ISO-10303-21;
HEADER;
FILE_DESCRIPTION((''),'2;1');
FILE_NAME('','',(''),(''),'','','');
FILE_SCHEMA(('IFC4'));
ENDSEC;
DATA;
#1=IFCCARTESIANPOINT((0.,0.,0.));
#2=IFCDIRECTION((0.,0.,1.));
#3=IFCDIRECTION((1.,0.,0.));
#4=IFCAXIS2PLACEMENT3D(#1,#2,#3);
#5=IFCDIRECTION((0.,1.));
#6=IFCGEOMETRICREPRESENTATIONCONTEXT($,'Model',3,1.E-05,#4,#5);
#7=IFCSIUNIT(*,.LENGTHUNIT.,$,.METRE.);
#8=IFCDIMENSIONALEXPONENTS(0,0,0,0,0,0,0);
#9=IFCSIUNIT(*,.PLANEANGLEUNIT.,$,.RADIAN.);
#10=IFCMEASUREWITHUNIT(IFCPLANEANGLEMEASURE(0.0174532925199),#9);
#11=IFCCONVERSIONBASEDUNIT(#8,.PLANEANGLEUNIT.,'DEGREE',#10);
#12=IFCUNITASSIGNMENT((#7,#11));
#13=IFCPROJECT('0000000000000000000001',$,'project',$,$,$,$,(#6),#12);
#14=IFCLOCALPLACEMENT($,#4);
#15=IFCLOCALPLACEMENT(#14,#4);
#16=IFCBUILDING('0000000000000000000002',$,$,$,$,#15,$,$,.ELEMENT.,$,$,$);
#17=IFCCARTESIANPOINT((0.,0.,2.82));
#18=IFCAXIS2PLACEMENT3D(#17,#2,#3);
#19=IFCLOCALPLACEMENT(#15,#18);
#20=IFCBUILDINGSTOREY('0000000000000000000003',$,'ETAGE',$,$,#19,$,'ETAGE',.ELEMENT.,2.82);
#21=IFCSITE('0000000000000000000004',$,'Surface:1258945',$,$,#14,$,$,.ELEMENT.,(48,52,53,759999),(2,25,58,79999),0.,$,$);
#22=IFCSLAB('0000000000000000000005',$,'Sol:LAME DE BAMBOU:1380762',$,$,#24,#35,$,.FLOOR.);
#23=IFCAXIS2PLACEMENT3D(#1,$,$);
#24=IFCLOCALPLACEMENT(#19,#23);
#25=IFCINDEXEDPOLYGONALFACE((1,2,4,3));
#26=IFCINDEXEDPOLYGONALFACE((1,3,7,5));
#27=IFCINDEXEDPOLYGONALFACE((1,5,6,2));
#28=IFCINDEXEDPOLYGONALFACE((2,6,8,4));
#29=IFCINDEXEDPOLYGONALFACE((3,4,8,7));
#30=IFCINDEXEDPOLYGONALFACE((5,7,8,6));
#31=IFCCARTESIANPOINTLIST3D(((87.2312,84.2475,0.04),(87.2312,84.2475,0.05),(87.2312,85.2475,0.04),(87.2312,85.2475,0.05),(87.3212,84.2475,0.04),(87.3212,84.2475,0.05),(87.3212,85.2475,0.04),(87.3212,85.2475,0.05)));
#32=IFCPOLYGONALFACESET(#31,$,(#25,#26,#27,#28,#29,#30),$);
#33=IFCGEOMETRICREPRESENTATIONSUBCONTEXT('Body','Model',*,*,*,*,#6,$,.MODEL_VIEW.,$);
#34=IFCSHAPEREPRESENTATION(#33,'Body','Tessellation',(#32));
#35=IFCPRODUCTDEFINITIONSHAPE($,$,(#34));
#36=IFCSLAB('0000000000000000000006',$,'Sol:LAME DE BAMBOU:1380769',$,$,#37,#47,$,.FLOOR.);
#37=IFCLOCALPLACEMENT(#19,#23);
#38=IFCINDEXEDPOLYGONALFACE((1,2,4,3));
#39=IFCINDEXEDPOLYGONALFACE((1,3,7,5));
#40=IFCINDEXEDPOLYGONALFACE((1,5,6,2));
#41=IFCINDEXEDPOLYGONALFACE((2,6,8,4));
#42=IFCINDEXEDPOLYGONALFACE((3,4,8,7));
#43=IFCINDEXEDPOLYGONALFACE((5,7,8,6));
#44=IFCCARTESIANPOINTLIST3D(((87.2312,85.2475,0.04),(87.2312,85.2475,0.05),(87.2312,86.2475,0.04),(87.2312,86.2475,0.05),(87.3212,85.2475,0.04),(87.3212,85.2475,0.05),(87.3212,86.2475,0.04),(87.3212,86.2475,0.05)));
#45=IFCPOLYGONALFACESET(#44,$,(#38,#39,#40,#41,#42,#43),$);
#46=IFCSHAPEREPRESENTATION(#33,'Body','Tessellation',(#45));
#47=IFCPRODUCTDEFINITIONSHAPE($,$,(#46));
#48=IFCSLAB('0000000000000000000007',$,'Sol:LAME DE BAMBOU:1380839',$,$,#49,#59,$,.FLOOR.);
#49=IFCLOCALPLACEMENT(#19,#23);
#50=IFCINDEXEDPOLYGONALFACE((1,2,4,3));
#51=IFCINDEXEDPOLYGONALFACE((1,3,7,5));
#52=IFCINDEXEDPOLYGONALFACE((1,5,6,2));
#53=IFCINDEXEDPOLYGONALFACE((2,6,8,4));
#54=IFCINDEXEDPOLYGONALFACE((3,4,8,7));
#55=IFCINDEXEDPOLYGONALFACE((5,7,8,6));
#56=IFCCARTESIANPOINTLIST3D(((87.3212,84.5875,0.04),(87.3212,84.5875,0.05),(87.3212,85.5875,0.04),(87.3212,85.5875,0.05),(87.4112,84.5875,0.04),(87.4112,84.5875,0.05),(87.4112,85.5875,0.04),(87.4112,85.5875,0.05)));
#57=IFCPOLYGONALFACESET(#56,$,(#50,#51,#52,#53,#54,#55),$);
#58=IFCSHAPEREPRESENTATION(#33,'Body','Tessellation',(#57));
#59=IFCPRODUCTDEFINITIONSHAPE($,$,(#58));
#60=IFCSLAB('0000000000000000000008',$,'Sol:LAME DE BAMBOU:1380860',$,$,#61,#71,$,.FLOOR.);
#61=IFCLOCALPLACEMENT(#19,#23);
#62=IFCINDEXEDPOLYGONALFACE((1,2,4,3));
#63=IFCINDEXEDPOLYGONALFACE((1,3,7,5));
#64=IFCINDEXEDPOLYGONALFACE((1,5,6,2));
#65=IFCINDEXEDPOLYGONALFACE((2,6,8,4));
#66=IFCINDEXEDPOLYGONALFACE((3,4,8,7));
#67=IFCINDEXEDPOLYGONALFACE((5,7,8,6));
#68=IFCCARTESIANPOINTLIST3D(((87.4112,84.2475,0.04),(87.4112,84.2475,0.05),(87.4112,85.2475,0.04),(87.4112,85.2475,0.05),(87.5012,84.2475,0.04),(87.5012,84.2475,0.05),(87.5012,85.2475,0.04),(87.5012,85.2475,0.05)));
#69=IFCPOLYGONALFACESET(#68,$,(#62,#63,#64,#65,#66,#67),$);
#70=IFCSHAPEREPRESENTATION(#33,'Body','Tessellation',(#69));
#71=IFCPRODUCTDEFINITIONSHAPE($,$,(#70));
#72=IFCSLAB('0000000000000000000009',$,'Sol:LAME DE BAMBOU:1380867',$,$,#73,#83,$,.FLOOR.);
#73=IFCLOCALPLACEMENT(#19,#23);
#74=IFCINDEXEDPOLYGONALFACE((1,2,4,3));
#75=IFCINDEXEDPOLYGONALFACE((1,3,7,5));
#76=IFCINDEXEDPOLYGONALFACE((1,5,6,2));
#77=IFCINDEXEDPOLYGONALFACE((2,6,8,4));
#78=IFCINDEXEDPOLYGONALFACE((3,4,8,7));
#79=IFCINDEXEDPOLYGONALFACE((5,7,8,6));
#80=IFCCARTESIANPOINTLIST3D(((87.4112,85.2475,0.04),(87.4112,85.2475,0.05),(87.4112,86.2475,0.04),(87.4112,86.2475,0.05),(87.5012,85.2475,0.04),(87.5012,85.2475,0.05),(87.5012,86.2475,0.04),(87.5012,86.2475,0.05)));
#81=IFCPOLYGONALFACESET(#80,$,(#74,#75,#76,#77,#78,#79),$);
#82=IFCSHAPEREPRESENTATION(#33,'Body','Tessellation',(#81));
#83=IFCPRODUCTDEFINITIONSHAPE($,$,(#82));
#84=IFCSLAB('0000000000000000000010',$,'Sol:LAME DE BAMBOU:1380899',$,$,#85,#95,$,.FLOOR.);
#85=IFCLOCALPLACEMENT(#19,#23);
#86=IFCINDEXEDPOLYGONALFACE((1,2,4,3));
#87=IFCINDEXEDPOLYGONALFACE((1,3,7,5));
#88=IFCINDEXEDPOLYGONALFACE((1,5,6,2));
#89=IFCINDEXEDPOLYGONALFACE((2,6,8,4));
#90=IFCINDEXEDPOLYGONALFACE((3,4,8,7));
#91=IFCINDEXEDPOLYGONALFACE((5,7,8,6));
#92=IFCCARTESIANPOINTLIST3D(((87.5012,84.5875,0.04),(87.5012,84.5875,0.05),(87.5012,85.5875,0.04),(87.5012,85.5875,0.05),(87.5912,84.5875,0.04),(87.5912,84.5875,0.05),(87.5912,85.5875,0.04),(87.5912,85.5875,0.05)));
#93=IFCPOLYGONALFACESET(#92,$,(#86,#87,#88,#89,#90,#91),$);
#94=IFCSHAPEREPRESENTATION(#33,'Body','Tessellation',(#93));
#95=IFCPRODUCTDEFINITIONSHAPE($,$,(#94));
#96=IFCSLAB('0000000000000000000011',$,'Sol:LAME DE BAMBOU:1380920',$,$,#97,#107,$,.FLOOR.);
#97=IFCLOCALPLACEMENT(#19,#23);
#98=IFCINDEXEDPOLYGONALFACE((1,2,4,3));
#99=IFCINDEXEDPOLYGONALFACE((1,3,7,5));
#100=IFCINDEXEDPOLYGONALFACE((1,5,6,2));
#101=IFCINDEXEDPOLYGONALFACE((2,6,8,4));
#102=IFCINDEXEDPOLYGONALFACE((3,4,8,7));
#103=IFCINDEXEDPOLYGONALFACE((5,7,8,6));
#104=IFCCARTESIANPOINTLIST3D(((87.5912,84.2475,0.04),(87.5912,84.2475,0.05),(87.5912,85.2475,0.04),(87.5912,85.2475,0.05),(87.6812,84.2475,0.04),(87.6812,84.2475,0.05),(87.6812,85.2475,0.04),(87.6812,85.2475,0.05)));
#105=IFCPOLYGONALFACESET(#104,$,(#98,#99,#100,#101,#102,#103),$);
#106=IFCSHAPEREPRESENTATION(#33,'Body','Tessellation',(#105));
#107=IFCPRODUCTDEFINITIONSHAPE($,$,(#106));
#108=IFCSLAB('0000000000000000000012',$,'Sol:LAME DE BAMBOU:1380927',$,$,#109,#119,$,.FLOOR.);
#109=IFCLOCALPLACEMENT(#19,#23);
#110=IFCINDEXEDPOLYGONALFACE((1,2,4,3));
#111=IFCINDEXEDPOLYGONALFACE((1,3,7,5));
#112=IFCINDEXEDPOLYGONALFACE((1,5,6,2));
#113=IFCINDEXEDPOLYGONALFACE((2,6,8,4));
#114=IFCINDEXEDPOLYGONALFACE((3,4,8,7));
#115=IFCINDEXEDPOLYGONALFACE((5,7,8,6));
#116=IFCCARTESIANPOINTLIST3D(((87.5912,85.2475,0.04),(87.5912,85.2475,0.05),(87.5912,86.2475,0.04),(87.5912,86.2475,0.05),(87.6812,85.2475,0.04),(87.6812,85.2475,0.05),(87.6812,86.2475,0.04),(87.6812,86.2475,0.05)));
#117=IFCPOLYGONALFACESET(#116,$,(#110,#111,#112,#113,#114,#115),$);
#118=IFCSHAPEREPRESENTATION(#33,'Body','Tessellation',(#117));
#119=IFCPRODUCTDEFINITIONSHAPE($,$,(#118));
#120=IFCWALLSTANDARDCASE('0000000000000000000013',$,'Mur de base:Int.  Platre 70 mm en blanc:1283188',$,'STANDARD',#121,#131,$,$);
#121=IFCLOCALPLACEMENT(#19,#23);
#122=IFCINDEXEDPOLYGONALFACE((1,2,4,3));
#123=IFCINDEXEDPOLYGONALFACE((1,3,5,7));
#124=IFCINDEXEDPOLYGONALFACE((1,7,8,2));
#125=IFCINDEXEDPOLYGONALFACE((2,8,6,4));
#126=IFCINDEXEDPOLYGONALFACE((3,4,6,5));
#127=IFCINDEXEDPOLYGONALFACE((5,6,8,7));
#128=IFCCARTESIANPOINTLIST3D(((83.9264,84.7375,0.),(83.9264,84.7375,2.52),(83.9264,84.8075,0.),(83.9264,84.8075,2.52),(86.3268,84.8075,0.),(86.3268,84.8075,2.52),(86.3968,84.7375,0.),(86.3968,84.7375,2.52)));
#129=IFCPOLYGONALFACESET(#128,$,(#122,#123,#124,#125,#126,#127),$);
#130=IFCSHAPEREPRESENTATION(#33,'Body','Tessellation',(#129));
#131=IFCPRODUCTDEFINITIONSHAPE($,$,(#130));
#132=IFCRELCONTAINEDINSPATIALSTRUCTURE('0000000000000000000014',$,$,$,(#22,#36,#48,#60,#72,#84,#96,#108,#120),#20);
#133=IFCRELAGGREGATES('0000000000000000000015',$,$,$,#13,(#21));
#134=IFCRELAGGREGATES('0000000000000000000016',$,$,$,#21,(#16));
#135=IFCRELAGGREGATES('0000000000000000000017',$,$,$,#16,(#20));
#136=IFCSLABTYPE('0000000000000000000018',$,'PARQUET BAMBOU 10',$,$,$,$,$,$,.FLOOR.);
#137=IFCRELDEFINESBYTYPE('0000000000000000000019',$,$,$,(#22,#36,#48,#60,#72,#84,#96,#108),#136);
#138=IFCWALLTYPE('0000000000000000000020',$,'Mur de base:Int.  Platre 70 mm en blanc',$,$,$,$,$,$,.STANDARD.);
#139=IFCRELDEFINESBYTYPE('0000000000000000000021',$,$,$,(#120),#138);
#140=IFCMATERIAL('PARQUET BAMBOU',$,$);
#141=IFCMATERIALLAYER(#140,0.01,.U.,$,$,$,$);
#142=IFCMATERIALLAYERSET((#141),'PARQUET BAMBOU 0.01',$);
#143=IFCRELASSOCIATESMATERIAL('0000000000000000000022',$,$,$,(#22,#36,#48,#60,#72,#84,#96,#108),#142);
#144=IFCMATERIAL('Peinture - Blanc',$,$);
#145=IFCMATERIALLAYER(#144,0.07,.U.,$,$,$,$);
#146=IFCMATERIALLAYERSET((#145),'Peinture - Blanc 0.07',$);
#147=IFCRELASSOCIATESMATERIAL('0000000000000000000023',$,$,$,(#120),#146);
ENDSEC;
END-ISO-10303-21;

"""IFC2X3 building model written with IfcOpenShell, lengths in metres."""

from ifc_helpers import new_model, entity, si_unit, converted_unit, direction, frame, origin_with_axes, place, context, subcontext, project, spatial, polyline, outline, extrude, material, layer, layer_set, layer_usage, type_object, element, save


model = new_model("IFC2X3")

# Units and contexts
model_context = context("Model", 3, precision=1e-05, world=origin_with_axes(), true_north=direction((0.0, 1.0)))
body_context = subcontext(model_context, "Body", "Model", "MODEL_VIEW")
ifc_project = project(units=[si_unit("LENGTHUNIT", "METRE"), converted_unit("PLANEANGLEUNIT", "DEGREE", entity("IfcPlaneAngleMeasure", 0.0174532925199), si_unit("PLANEANGLEUNIT", "RADIAN"), dimensions=[0, 0, 0, 0, 0, 0, 0])], contexts=[model_context])

# Site, building, storey
site_placement = place(None, origin_with_axes())
site = spatial("IfcSite", under=ifc_project, at=site_placement, Name="Surface:1258945", CompositionType="ELEMENT", RefLatitude=(48, 52, 53, 759999), RefLongitude=(2, 25, 58, 79999), RefElevation=0.0)
building_placement = place(site_placement, origin_with_axes())
building = spatial("IfcBuilding", under=site, at=building_placement, CompositionType="ELEMENT")
storey_placement = place(building_placement, frame((0.0, 0.0, 2.82), z_axis=(0.0, 0.0, 1.0), x_axis=(1.0, 0.0, 0.0)))
storey = spatial("IfcBuildingStorey", under=building, at=storey_placement, Name="ETAGE", LongName="ETAGE", CompositionType="ELEMENT", Elevation=2.82)

# Slabs
ifc_material_1 = material(Name="PARQUET BAMBOU")
ifc_layer_1 = layer(ifc_material_1, 0.01, ventilated="UNKNOWN")
ifc_layer_set_1 = layer_set([ifc_layer_1], Name="PARQUET BAMBOU 0.01")
slab_type = type_object("IfcSlabType", Name="PARQUET BAMBOU 10", PredefinedType="FLOOR")
ifc_layer_usage_1 = layer_usage(ifc_layer_set_1, "AXIS3", "NEGATIVE", 0.01)
slab_1_placement = place(storey_placement, frame((87.2312, 85.2475, 0.05), z_axis=(0.0, 0.0, 1.0), x_axis=(1.0, 0.0, 0.0)))
element("IfcSlab", 1, at=slab_1_placement, inside=storey, type_object=slab_type, material=ifc_layer_usage_1, Name="Sol:LAME DE BAMBOU:1380762", PredefinedType="FLOOR", context=body_context, shape_type="SweptSolid", body=[
    extrude(outline(polyline([(0.0, 0.0), (0.0, -1.0), (0.09, -1.0), (0.09, 0.0), (0.0, 0.0)])), frame((0.0, 0.0, -0.01), z_axis=(0.0, 0.0, 1.0), x_axis=(1.0, 0.0, 0.0)), (0.0, 0.0, 1.0), 0.01),
])
ifc_layer_usage_2 = layer_usage(ifc_layer_set_1, "AXIS3", "NEGATIVE", 0.01)
slab_2_placement = place(storey_placement, frame((87.2312, 86.2475, 0.05), z_axis=(0.0, 0.0, 1.0), x_axis=(1.0, 0.0, 0.0)))
element("IfcSlab", 2, at=slab_2_placement, inside=storey, type_object=slab_type, material=ifc_layer_usage_2, Name="Sol:LAME DE BAMBOU:1380769", PredefinedType="FLOOR", context=body_context, shape_type="SweptSolid", body=[
    extrude(outline(polyline([(0.0, 0.0), (0.0, -1.0), (0.09, -1.0), (0.09, 0.0), (0.0, 0.0)])), frame((0.0, 0.0, -0.01), z_axis=(0.0, 0.0, 1.0), x_axis=(1.0, 0.0, 0.0)), (0.0, 0.0, 1.0), 0.01),
])
ifc_layer_usage_3 = layer_usage(ifc_layer_set_1, "AXIS3", "NEGATIVE", 0.01)
slab_3_placement = place(storey_placement, frame((87.3212, 85.5875, 0.05), z_axis=(0.0, 0.0, 1.0), x_axis=(1.0, 0.0, 0.0)))
element("IfcSlab", 3, at=slab_3_placement, inside=storey, type_object=slab_type, material=ifc_layer_usage_3, Name="Sol:LAME DE BAMBOU:1380839", PredefinedType="FLOOR", context=body_context, shape_type="SweptSolid", body=[
    extrude(outline(polyline([(0.0, 0.0), (0.0, -1.0), (0.09, -1.0), (0.09, 0.0), (0.0, 0.0)])), frame((0.0, 0.0, -0.01), z_axis=(0.0, 0.0, 1.0), x_axis=(1.0, 0.0, 0.0)), (0.0, 0.0, 1.0), 0.01),
])
ifc_layer_usage_4 = layer_usage(ifc_layer_set_1, "AXIS3", "NEGATIVE", 0.01)
slab_4_placement = place(storey_placement, frame((87.4112, 85.2475, 0.05), z_axis=(0.0, 0.0, 1.0), x_axis=(1.0, 0.0, 0.0)))
element("IfcSlab", 4, at=slab_4_placement, inside=storey, type_object=slab_type, material=ifc_layer_usage_4, Name="Sol:LAME DE BAMBOU:1380860", PredefinedType="FLOOR", context=body_context, shape_type="SweptSolid", body=[
    extrude(outline(polyline([(0.0, 0.0), (0.0, -1.0), (0.09, -1.0), (0.09, 0.0), (0.0, 0.0)])), frame((0.0, 0.0, -0.01), z_axis=(0.0, 0.0, 1.0), x_axis=(1.0, 0.0, 0.0)), (0.0, 0.0, 1.0), 0.01),
])
ifc_layer_usage_5 = layer_usage(ifc_layer_set_1, "AXIS3", "NEGATIVE", 0.01)
slab_5_placement = place(storey_placement, frame((87.4112, 86.2475, 0.05), z_axis=(0.0, 0.0, 1.0), x_axis=(1.0, 0.0, 0.0)))
element("IfcSlab", 5, at=slab_5_placement, inside=storey, type_object=slab_type, material=ifc_layer_usage_5, Name="Sol:LAME DE BAMBOU:1380867", PredefinedType="FLOOR", context=body_context, shape_type="SweptSolid", body=[
    extrude(outline(polyline([(0.0, 0.0), (0.0, -1.0), (0.09, -1.0), (0.09, 0.0), (0.0, 0.0)])), frame((0.0, 0.0, -0.01), z_axis=(0.0, 0.0, 1.0), x_axis=(1.0, 0.0, 0.0)), (0.0, 0.0, 1.0), 0.01),
])
ifc_layer_usage_6 = layer_usage(ifc_layer_set_1, "AXIS3", "NEGATIVE", 0.01)
slab_6_placement = place(storey_placement, frame((87.5012, 85.5875, 0.05), z_axis=(0.0, 0.0, 1.0), x_axis=(1.0, 0.0, 0.0)))
element("IfcSlab", 6, at=slab_6_placement, inside=storey, type_object=slab_type, material=ifc_layer_usage_6, Name="Sol:LAME DE BAMBOU:1380899", PredefinedType="FLOOR", context=body_context, shape_type="SweptSolid", body=[
    extrude(outline(polyline([(0.0, 0.0), (0.0, -1.0), (0.09, -1.0), (0.09, 0.0), (0.0, 0.0)])), frame((0.0, 0.0, -0.01), z_axis=(0.0, 0.0, 1.0), x_axis=(1.0, 0.0, 0.0)), (0.0, 0.0, 1.0), 0.01),
])
ifc_layer_usage_7 = layer_usage(ifc_layer_set_1, "AXIS3", "NEGATIVE", 0.01)
slab_7_placement = place(storey_placement, frame((87.5912, 85.2475, 0.05), z_axis=(0.0, 0.0, 1.0), x_axis=(1.0, 0.0, 0.0)))
element("IfcSlab", 7, at=slab_7_placement, inside=storey, type_object=slab_type, material=ifc_layer_usage_7, Name="Sol:LAME DE BAMBOU:1380920", PredefinedType="FLOOR", context=body_context, shape_type="SweptSolid", body=[
    extrude(outline(polyline([(0.0, 0.0), (0.0, -1.0), (0.09, -1.0), (0.09, 0.0), (0.0, 0.0)])), frame((0.0, 0.0, -0.01), z_axis=(0.0, 0.0, 1.0), x_axis=(1.0, 0.0, 0.0)), (0.0, 0.0, 1.0), 0.01),
])
ifc_layer_usage_8 = layer_usage(ifc_layer_set_1, "AXIS3", "NEGATIVE", 0.01)
slab_8_placement = place(storey_placement, frame((87.5912, 86.2475, 0.05), z_axis=(0.0, 0.0, 1.0), x_axis=(1.0, 0.0, 0.0)))
element("IfcSlab", 8, at=slab_8_placement, inside=storey, type_object=slab_type, material=ifc_layer_usage_8, Name="Sol:LAME DE BAMBOU:1380927", PredefinedType="FLOOR", context=body_context, shape_type="SweptSolid", body=[
    extrude(outline(polyline([(0.0, 0.0), (0.0, -1.0), (0.09, -1.0), (0.09, 0.0), (0.0, 0.0)])), frame((0.0, 0.0, -0.01), z_axis=(0.0, 0.0, 1.0), x_axis=(1.0, 0.0, 0.0)), (0.0, 0.0, 1.0), 0.01),
])

# Wall
ifc_material_2 = material(Name="Peinture - Blanc")
ifc_layer_2 = layer(ifc_material_2, 0.07, ventilated="UNKNOWN")
ifc_layer_set_2 = layer_set([ifc_layer_2], Name="Peinture - Blanc 0.07")
ifc_layer_usage_9 = layer_usage(ifc_layer_set_2, "AXIS2", "POSITIVE", -0.035)
wall_type = type_object("IfcWallType", Name="Mur de base:Int.  Platre 70 mm en blanc", PredefinedType="STANDARD")
wall_placement = place(storey_placement, frame((86.3618, 84.7725, 0.0), z_axis=(0.0, 0.0, 1.0), x_axis=(-1.0, 0.0, 0.0)))
element("IfcWallStandardCase", 9, at=wall_placement, inside=storey, type_object=wall_type, material=ifc_layer_usage_9, Name="Mur de base:Int.  Platre 70 mm en blanc:1283188", ObjectType="STANDARD", context=body_context, shape_type="SweptSolid", body=[
    extrude(outline(polyline([(0.035, -0.035), (2.4354, -0.035), (2.4354, 0.035), (-0.035, 0.035), (0.035, -0.035)])), origin_with_axes(), (0.0, 0.0, 1.0), 2.52),
])

save(model, "model.ifc")
